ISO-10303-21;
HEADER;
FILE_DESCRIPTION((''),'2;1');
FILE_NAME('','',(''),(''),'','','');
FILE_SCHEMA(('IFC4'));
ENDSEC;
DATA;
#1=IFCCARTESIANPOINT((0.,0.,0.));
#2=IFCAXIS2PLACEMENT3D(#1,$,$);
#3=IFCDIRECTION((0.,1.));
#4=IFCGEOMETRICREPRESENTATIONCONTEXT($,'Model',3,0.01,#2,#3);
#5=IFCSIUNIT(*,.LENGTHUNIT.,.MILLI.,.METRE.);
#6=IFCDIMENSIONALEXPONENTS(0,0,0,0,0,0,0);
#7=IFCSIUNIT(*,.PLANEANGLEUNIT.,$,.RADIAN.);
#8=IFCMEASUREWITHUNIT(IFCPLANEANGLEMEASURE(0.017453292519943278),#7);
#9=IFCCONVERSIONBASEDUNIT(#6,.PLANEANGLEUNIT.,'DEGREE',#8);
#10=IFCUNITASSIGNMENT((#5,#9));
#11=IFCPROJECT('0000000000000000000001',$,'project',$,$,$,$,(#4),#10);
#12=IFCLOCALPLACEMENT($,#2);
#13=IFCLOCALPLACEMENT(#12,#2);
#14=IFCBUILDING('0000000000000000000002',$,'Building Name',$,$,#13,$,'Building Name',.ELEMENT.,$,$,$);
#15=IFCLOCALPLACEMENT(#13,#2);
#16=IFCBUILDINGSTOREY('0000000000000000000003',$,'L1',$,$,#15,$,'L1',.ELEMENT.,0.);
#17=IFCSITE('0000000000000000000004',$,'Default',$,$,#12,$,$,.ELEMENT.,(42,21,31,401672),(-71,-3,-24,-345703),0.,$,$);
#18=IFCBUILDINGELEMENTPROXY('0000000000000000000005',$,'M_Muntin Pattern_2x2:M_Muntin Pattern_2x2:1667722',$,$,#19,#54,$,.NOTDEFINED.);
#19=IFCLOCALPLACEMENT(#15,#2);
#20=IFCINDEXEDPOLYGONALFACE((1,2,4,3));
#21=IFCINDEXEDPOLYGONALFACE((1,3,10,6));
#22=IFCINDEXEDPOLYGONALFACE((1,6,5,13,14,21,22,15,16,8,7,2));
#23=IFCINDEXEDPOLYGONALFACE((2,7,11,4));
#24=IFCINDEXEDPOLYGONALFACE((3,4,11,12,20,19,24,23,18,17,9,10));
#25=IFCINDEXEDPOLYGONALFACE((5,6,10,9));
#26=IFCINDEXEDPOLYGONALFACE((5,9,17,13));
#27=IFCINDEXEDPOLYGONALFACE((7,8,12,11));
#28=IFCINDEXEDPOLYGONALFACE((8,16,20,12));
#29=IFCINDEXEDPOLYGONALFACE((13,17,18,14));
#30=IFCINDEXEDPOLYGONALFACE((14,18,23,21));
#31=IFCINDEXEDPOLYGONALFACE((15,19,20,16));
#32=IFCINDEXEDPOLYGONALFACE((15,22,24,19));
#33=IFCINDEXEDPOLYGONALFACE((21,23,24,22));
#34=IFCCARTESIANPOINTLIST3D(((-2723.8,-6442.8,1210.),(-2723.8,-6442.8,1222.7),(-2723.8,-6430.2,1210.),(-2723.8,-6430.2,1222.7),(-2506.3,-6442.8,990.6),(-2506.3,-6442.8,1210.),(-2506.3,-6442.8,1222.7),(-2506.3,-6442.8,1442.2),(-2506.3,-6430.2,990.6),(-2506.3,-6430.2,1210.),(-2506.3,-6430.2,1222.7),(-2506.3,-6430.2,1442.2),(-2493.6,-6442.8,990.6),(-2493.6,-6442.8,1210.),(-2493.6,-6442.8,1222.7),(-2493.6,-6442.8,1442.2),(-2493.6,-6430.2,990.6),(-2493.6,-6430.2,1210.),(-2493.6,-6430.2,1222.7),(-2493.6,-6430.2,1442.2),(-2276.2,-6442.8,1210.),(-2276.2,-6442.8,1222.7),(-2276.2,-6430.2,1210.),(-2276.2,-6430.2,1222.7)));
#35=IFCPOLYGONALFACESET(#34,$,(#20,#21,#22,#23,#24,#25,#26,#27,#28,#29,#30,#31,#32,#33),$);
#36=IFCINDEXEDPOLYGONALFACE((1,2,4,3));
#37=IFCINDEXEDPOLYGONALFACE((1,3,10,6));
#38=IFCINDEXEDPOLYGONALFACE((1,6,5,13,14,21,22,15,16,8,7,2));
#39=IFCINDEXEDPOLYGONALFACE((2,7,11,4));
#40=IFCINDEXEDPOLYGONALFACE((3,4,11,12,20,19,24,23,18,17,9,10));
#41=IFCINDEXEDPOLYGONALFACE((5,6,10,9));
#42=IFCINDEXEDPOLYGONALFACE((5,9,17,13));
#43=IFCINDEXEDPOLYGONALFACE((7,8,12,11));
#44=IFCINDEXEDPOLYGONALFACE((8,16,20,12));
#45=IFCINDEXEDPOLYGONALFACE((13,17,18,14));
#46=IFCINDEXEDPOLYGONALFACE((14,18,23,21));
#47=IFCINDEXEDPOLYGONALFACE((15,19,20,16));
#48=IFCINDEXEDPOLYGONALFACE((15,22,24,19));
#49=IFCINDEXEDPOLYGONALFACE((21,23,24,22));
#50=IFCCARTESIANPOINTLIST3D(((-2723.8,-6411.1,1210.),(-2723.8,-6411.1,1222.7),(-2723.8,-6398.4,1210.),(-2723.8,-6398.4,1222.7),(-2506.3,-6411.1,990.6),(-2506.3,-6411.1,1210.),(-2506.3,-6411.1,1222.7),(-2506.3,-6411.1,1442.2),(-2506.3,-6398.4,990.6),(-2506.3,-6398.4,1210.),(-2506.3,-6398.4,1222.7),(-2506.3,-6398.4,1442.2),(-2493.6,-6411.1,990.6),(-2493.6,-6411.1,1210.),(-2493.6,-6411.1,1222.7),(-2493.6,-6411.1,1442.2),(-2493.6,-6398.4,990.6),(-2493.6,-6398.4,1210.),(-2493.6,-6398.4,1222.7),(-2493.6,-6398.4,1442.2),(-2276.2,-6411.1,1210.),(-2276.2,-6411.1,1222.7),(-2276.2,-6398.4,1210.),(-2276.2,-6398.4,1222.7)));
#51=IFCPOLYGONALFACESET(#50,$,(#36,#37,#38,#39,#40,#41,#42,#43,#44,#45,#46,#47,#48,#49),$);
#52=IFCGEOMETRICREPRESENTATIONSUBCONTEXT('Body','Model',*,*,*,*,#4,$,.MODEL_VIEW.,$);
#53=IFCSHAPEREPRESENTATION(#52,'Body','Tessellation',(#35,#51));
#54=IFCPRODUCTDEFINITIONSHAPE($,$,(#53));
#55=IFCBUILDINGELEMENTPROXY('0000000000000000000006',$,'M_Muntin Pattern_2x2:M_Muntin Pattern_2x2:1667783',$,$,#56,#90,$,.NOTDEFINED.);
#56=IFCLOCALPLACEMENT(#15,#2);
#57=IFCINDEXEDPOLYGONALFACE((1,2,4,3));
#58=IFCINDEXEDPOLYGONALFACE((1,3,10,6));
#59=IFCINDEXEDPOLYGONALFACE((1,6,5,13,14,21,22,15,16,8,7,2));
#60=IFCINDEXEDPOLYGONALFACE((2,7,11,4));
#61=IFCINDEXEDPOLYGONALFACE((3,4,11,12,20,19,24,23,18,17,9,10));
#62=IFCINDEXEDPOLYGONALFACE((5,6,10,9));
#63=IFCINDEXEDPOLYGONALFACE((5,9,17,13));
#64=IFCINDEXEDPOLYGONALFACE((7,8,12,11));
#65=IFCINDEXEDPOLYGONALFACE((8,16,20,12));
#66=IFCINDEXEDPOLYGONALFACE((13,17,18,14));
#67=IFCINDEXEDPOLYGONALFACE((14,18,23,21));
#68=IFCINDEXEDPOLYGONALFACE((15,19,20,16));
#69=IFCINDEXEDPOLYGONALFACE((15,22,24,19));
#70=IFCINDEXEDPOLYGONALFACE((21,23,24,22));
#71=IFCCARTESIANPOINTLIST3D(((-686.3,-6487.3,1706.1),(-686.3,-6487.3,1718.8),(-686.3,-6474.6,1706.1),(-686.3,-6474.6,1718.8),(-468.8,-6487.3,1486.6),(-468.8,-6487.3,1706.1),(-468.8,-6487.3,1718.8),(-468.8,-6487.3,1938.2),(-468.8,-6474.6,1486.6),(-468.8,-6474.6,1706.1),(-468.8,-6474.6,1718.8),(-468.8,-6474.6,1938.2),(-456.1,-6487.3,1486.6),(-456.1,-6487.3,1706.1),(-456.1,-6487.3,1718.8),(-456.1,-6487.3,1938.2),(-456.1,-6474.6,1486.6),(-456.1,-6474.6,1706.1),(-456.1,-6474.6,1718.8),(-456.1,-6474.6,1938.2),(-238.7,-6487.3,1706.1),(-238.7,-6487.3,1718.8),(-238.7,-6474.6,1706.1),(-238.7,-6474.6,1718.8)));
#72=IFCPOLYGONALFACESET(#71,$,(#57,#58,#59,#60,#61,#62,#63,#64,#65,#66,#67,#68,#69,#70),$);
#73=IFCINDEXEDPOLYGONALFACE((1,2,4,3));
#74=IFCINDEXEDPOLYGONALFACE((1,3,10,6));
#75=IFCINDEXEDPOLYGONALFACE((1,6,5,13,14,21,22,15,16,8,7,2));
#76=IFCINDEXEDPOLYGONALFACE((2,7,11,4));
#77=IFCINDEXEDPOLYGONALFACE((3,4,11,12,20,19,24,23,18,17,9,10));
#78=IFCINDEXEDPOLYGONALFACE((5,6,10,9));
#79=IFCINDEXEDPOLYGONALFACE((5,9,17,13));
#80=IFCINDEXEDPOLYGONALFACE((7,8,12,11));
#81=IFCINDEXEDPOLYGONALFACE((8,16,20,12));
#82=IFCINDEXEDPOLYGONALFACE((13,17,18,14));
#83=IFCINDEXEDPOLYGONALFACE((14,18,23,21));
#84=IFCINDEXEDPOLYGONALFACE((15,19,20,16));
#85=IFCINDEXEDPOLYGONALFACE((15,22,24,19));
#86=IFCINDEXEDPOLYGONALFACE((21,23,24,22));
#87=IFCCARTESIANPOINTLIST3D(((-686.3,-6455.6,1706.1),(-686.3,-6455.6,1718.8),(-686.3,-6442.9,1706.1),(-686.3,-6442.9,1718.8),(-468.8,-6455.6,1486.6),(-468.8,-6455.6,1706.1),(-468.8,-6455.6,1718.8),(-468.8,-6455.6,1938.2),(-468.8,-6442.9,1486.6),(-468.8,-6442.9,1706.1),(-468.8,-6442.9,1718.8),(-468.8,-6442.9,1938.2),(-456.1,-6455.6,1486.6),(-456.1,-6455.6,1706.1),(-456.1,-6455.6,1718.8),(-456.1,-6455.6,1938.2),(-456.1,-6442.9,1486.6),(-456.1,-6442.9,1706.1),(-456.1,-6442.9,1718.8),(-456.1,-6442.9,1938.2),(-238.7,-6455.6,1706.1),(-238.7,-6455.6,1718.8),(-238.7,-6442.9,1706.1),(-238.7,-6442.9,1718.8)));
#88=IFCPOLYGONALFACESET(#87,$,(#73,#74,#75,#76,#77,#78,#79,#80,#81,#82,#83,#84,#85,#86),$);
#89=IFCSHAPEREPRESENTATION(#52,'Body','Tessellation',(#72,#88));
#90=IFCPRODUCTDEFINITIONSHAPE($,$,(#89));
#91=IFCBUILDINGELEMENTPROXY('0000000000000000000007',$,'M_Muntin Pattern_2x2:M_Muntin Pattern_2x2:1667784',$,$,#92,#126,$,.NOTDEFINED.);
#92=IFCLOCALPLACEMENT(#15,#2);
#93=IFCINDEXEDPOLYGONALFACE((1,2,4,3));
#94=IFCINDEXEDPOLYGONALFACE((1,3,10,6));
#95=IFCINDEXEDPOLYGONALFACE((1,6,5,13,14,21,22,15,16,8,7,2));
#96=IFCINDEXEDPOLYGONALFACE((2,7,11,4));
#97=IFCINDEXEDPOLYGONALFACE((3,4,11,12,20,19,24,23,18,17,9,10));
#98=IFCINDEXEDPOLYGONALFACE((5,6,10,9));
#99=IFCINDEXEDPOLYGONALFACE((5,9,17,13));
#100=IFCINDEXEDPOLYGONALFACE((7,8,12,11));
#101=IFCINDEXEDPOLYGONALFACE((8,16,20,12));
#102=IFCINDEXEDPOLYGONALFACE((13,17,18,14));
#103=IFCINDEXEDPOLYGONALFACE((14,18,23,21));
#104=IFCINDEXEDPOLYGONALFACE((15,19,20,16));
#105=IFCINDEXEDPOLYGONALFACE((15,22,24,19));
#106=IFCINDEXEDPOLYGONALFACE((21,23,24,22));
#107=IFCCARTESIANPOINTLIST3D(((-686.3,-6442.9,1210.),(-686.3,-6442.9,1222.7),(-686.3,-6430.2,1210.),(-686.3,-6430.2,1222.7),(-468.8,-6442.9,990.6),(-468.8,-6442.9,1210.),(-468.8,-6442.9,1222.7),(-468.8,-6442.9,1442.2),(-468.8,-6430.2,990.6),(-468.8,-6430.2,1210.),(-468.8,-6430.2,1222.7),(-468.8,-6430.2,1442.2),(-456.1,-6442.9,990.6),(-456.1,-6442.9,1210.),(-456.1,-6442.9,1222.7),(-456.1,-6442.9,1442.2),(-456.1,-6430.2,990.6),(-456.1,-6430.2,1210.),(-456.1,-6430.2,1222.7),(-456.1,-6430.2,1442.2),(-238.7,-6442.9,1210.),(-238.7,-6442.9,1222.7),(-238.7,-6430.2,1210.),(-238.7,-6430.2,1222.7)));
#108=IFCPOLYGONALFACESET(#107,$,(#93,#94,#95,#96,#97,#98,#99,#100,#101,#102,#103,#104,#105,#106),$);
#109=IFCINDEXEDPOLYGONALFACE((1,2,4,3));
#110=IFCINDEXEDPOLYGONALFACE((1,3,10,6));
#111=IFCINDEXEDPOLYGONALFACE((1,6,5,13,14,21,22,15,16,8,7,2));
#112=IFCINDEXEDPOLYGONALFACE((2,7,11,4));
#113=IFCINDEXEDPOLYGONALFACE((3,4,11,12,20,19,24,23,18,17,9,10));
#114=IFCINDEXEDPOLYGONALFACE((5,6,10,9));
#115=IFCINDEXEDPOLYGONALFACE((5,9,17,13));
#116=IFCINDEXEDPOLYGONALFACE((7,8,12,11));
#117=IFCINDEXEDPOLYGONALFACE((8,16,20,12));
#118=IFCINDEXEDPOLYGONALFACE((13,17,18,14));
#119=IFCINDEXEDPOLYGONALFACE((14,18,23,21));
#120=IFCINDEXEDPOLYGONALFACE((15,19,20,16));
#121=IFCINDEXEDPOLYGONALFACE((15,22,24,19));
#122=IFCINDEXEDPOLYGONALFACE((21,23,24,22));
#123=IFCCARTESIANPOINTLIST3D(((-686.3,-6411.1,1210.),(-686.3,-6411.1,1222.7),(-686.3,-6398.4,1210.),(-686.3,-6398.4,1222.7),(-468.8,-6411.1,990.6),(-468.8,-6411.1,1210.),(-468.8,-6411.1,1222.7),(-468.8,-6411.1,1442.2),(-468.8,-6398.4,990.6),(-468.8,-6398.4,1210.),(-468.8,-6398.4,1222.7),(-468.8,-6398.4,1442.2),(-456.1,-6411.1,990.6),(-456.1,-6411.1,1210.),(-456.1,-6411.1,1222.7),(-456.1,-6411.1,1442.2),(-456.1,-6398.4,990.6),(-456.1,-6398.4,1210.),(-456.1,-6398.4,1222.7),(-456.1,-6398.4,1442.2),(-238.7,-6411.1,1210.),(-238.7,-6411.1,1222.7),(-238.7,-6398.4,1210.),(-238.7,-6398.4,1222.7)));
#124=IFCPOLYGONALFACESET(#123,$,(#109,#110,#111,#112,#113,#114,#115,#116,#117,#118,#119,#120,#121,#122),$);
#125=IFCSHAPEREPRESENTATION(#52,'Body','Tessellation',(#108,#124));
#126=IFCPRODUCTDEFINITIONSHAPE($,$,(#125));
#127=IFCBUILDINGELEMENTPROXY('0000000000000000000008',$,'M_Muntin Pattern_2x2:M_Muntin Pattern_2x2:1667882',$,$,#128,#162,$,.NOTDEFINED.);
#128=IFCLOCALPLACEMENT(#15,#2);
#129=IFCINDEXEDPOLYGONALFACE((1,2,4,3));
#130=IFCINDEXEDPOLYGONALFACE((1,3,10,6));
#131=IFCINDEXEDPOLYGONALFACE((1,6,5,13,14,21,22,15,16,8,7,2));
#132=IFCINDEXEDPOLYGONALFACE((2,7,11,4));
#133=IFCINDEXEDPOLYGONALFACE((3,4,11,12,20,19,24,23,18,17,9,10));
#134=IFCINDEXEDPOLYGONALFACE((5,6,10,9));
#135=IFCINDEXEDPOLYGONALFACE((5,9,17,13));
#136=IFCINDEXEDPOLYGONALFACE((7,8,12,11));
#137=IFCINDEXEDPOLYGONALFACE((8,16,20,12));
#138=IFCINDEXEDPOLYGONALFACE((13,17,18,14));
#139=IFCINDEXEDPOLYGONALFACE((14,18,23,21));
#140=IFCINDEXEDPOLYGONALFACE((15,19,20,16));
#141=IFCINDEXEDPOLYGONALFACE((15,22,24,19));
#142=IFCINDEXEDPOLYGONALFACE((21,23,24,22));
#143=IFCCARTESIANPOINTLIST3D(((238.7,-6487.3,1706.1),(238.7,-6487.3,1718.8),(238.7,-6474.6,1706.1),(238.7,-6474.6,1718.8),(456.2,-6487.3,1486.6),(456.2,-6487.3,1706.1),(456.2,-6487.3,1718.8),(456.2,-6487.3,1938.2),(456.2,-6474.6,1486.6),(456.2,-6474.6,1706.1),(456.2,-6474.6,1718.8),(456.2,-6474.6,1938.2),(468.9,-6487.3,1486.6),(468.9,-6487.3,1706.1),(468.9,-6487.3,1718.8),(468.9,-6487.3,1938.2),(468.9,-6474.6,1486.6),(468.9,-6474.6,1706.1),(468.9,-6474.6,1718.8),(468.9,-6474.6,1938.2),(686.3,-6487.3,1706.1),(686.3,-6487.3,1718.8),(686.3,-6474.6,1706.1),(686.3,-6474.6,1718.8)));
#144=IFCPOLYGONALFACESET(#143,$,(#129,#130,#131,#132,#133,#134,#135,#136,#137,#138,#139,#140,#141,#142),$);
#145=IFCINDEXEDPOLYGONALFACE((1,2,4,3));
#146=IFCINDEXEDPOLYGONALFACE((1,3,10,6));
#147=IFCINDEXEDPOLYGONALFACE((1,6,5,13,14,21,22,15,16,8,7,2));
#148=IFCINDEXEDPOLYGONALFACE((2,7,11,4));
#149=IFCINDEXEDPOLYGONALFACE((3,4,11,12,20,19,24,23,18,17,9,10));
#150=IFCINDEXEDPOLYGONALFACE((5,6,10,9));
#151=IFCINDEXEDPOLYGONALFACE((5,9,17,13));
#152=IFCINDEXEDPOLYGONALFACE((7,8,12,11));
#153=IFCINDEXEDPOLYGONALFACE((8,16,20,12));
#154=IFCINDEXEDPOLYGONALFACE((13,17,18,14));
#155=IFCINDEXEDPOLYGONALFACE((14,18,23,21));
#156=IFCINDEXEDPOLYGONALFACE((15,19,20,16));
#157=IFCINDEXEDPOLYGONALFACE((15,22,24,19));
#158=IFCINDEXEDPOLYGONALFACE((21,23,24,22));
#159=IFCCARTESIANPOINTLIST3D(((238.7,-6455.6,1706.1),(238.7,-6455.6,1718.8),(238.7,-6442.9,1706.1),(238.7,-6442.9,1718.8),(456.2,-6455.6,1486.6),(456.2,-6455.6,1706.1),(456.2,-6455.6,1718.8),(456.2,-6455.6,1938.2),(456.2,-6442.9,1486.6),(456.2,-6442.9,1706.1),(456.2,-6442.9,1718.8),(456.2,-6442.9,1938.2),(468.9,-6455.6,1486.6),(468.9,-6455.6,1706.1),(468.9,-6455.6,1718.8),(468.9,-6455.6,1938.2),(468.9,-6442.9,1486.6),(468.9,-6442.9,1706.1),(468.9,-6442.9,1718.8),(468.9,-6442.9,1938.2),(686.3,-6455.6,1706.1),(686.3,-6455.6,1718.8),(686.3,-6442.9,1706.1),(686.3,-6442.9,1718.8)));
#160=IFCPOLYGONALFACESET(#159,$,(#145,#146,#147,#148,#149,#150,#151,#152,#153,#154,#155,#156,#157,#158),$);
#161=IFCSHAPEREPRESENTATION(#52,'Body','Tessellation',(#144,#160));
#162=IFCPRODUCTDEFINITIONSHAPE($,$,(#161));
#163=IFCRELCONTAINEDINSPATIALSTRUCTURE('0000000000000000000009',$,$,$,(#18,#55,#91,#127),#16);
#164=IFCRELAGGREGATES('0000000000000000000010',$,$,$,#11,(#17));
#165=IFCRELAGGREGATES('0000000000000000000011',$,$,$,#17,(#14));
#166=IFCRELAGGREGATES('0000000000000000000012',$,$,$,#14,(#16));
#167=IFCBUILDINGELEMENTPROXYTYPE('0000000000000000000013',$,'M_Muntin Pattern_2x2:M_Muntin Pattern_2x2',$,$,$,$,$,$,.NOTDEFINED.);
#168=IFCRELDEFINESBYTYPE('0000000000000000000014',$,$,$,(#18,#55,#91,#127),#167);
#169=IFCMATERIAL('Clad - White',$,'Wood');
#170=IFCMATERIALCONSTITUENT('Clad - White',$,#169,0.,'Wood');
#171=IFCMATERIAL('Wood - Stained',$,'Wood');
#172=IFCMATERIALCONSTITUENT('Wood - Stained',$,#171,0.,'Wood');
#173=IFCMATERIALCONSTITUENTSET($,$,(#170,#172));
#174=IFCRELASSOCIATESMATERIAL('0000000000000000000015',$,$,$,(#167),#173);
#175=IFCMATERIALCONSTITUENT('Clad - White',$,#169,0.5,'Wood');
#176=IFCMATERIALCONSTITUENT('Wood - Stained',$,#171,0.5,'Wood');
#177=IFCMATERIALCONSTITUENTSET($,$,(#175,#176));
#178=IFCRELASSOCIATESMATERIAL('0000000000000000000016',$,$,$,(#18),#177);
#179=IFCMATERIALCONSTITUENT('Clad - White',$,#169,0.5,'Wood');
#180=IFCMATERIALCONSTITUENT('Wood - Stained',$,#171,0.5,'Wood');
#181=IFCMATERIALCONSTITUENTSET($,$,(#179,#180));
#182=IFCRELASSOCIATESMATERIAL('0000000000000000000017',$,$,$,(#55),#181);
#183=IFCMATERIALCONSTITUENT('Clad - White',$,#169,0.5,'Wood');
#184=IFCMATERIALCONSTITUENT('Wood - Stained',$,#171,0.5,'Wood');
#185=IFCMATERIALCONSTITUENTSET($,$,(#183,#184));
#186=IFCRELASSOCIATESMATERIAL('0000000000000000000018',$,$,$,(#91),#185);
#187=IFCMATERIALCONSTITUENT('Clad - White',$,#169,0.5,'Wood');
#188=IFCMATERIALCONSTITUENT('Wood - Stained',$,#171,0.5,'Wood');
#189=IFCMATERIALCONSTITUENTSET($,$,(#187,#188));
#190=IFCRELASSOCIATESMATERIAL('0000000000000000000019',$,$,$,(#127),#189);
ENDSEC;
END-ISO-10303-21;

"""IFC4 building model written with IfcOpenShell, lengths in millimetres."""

from ifc_helpers import new_model, entity, si_unit, converted_unit, direction, frame, origin, place, context, subcontext, project, spatial, indexed_curve, outline, extrude, source, transform, mapped, material, constituent, constituent_set, type_object, type_shapes, element, save


model = new_model("IFC4")

# Units and contexts
model_context = context("Model", 3, precision=0.01, world=origin(), true_north=direction((0.0, 1.0)))
body_context = subcontext(model_context, "Body", "Model", "MODEL_VIEW")
ifc_project = project(units=[si_unit("LENGTHUNIT", "METRE", prefix="MILLI"), converted_unit("PLANEANGLEUNIT", "DEGREE", entity("IfcPlaneAngleMeasure", 0.017453292519943278), si_unit("PLANEANGLEUNIT", "RADIAN"), dimensions=[0, 0, 0, 0, 0, 0, 0])], contexts=[model_context])

# Site, building, storey
site_placement = place(None, origin())
site = spatial("IfcSite", under=ifc_project, at=site_placement, Name="Default", CompositionType="ELEMENT", RefLatitude=(42, 21, 31, 401672), RefLongitude=(-71, -3, -24, -345703), RefElevation=0.0)
building_placement = place(site_placement, origin())
building = spatial("IfcBuilding", under=site, at=building_placement, Name="Building Name", LongName="Building Name", CompositionType="ELEMENT")
storey_placement = place(building_placement, origin())
storey = spatial("IfcBuildingStorey", under=building, at=storey_placement, Name="L1", LongName="L1", CompositionType="ELEMENT", Elevation=0.0)

# Building element proxies
ifc_material_1 = material(Name="Clad - White", Category="Wood")
ifc_material_2 = material(Name="Wood - Stained", Category="Wood")
ifc_constituent_1 = constituent(ifc_material_1, Name="Clad - White", Category="Wood", fraction=0.0)
ifc_constituent_2 = constituent(ifc_material_2, Name="Wood - Stained", Category="Wood", fraction=0.0)
ifc_constituent_set_1 = constituent_set(constituents=[ifc_constituent_1, ifc_constituent_2])
building_element_proxy_type_1 = type_object("IfcBuildingElementProxyType", Name="M_Muntin Pattern_2x2:M_Muntin Pattern_2x2", PredefinedType="NOTDEFINED", material=ifc_constituent_set_1)
shared_shape_1 = source(origin(), body_context, "Body", "SweptSolid", [
    extrude(outline(indexed_curve([(6.4, -6.4), (225.8, -6.4), (225.8, 6.3), (6.4, 6.3), (6.4, 223.8), (-6.3, 223.8), (-6.3, 6.3), (-225.8, 6.3), (-225.8, -6.4), (-6.3, -6.4), (-6.3, -223.8), (6.4, -223.8), (6.4, -6.4)], self_intersect=False)), frame((0.0, 9.5, 225.8), z_axis=(0.0, 1.0, 0.0), x_axis=(0.0, 0.0, 1.0)), (0.0, 0.0, 1.0), 12.7),
    extrude(outline(indexed_curve([(6.4, -6.4), (225.8, -6.4), (225.8, 6.3), (6.4, 6.3), (6.4, 223.8), (-6.3, 223.8), (-6.3, 6.3), (-225.8, 6.3), (-225.8, -6.4), (-6.3, -6.4), (-6.3, -223.8), (6.4, -223.8), (6.4, -6.4)], self_intersect=False)), frame((0.0, -22.2, 225.8), z_axis=(0.0, 1.0, 0.0), x_axis=(0.0, 0.0, 1.0)), (0.0, 0.0, 1.0), 12.7),
])
type_shapes(building_element_proxy_type_1, [shared_shape_1])
ifc_constituent_3 = constituent(ifc_material_1, Name="Clad - White", Category="Wood", fraction=0.5)
ifc_constituent_4 = constituent(ifc_material_2, Name="Wood - Stained", Category="Wood", fraction=0.5)
ifc_constituent_set_2 = constituent_set(constituents=[ifc_constituent_3, ifc_constituent_4])
proxy_1_placement = place(storey_placement, frame((-2500.0, -6420.6, 990.6), z_axis=(0.0, 0.0, 1.0), x_axis=(-1.0, 0.0, 0.0)))
element("IfcBuildingElementProxy", 1, at=proxy_1_placement, inside=storey, type_object=building_element_proxy_type_1, material=ifc_constituent_set_2, Name="M_Muntin Pattern_2x2:M_Muntin Pattern_2x2:1667722", PredefinedType="NOTDEFINED", context=body_context, shape_type="MappedRepresentation", body=[
    mapped(shared_shape_1, transform((0.0, 0.0, 0.0), scale=1.0)),
])
ifc_constituent_5 = constituent(ifc_material_1, Name="Clad - White", Category="Wood", fraction=0.5)
ifc_constituent_6 = constituent(ifc_material_2, Name="Wood - Stained", Category="Wood", fraction=0.5)
ifc_constituent_set_3 = constituent_set(constituents=[ifc_constituent_5, ifc_constituent_6])
proxy_2_placement = place(storey_placement, frame((-462.5, -6465.1, 1486.6), z_axis=(0.0, 0.0, 1.0), x_axis=(-1.0, 0.0, 0.0)))
element("IfcBuildingElementProxy", 2, at=proxy_2_placement, inside=storey, type_object=building_element_proxy_type_1, material=ifc_constituent_set_3, Name="M_Muntin Pattern_2x2:M_Muntin Pattern_2x2:1667783", PredefinedType="NOTDEFINED", context=body_context, shape_type="MappedRepresentation", body=[
    mapped(shared_shape_1, transform((0.0, 0.0, 0.0), scale=1.0)),
])
ifc_constituent_7 = constituent(ifc_material_1, Name="Clad - White", Category="Wood", fraction=0.5)
ifc_constituent_8 = constituent(ifc_material_2, Name="Wood - Stained", Category="Wood", fraction=0.5)
ifc_constituent_set_4 = constituent_set(constituents=[ifc_constituent_7, ifc_constituent_8])
proxy_3_placement = place(storey_placement, frame((-462.5, -6420.6, 990.6), z_axis=(0.0, 0.0, 1.0), x_axis=(-1.0, 0.0, 0.0)))
element("IfcBuildingElementProxy", 3, at=proxy_3_placement, inside=storey, type_object=building_element_proxy_type_1, material=ifc_constituent_set_4, Name="M_Muntin Pattern_2x2:M_Muntin Pattern_2x2:1667784", PredefinedType="NOTDEFINED", context=body_context, shape_type="MappedRepresentation", body=[
    mapped(shared_shape_1, transform((0.0, 0.0, 0.0), scale=1.0)),
])
ifc_constituent_9 = constituent(ifc_material_1, Name="Clad - White", Category="Wood", fraction=0.5)
ifc_constituent_10 = constituent(ifc_material_2, Name="Wood - Stained", Category="Wood", fraction=0.5)
ifc_constituent_set_5 = constituent_set(constituents=[ifc_constituent_9, ifc_constituent_10])
proxy_4_placement = place(storey_placement, frame((462.5, -6465.1, 1486.6), z_axis=(0.0, 0.0, 1.0), x_axis=(-1.0, 0.0, 0.0)))
element("IfcBuildingElementProxy", 4, at=proxy_4_placement, inside=storey, type_object=building_element_proxy_type_1, material=ifc_constituent_set_5, Name="M_Muntin Pattern_2x2:M_Muntin Pattern_2x2:1667882", PredefinedType="NOTDEFINED", context=body_context, shape_type="MappedRepresentation", body=[
    mapped(shared_shape_1, transform((0.0, 0.0, 0.0), scale=1.0)),
])

save(model, "model.ifc")
